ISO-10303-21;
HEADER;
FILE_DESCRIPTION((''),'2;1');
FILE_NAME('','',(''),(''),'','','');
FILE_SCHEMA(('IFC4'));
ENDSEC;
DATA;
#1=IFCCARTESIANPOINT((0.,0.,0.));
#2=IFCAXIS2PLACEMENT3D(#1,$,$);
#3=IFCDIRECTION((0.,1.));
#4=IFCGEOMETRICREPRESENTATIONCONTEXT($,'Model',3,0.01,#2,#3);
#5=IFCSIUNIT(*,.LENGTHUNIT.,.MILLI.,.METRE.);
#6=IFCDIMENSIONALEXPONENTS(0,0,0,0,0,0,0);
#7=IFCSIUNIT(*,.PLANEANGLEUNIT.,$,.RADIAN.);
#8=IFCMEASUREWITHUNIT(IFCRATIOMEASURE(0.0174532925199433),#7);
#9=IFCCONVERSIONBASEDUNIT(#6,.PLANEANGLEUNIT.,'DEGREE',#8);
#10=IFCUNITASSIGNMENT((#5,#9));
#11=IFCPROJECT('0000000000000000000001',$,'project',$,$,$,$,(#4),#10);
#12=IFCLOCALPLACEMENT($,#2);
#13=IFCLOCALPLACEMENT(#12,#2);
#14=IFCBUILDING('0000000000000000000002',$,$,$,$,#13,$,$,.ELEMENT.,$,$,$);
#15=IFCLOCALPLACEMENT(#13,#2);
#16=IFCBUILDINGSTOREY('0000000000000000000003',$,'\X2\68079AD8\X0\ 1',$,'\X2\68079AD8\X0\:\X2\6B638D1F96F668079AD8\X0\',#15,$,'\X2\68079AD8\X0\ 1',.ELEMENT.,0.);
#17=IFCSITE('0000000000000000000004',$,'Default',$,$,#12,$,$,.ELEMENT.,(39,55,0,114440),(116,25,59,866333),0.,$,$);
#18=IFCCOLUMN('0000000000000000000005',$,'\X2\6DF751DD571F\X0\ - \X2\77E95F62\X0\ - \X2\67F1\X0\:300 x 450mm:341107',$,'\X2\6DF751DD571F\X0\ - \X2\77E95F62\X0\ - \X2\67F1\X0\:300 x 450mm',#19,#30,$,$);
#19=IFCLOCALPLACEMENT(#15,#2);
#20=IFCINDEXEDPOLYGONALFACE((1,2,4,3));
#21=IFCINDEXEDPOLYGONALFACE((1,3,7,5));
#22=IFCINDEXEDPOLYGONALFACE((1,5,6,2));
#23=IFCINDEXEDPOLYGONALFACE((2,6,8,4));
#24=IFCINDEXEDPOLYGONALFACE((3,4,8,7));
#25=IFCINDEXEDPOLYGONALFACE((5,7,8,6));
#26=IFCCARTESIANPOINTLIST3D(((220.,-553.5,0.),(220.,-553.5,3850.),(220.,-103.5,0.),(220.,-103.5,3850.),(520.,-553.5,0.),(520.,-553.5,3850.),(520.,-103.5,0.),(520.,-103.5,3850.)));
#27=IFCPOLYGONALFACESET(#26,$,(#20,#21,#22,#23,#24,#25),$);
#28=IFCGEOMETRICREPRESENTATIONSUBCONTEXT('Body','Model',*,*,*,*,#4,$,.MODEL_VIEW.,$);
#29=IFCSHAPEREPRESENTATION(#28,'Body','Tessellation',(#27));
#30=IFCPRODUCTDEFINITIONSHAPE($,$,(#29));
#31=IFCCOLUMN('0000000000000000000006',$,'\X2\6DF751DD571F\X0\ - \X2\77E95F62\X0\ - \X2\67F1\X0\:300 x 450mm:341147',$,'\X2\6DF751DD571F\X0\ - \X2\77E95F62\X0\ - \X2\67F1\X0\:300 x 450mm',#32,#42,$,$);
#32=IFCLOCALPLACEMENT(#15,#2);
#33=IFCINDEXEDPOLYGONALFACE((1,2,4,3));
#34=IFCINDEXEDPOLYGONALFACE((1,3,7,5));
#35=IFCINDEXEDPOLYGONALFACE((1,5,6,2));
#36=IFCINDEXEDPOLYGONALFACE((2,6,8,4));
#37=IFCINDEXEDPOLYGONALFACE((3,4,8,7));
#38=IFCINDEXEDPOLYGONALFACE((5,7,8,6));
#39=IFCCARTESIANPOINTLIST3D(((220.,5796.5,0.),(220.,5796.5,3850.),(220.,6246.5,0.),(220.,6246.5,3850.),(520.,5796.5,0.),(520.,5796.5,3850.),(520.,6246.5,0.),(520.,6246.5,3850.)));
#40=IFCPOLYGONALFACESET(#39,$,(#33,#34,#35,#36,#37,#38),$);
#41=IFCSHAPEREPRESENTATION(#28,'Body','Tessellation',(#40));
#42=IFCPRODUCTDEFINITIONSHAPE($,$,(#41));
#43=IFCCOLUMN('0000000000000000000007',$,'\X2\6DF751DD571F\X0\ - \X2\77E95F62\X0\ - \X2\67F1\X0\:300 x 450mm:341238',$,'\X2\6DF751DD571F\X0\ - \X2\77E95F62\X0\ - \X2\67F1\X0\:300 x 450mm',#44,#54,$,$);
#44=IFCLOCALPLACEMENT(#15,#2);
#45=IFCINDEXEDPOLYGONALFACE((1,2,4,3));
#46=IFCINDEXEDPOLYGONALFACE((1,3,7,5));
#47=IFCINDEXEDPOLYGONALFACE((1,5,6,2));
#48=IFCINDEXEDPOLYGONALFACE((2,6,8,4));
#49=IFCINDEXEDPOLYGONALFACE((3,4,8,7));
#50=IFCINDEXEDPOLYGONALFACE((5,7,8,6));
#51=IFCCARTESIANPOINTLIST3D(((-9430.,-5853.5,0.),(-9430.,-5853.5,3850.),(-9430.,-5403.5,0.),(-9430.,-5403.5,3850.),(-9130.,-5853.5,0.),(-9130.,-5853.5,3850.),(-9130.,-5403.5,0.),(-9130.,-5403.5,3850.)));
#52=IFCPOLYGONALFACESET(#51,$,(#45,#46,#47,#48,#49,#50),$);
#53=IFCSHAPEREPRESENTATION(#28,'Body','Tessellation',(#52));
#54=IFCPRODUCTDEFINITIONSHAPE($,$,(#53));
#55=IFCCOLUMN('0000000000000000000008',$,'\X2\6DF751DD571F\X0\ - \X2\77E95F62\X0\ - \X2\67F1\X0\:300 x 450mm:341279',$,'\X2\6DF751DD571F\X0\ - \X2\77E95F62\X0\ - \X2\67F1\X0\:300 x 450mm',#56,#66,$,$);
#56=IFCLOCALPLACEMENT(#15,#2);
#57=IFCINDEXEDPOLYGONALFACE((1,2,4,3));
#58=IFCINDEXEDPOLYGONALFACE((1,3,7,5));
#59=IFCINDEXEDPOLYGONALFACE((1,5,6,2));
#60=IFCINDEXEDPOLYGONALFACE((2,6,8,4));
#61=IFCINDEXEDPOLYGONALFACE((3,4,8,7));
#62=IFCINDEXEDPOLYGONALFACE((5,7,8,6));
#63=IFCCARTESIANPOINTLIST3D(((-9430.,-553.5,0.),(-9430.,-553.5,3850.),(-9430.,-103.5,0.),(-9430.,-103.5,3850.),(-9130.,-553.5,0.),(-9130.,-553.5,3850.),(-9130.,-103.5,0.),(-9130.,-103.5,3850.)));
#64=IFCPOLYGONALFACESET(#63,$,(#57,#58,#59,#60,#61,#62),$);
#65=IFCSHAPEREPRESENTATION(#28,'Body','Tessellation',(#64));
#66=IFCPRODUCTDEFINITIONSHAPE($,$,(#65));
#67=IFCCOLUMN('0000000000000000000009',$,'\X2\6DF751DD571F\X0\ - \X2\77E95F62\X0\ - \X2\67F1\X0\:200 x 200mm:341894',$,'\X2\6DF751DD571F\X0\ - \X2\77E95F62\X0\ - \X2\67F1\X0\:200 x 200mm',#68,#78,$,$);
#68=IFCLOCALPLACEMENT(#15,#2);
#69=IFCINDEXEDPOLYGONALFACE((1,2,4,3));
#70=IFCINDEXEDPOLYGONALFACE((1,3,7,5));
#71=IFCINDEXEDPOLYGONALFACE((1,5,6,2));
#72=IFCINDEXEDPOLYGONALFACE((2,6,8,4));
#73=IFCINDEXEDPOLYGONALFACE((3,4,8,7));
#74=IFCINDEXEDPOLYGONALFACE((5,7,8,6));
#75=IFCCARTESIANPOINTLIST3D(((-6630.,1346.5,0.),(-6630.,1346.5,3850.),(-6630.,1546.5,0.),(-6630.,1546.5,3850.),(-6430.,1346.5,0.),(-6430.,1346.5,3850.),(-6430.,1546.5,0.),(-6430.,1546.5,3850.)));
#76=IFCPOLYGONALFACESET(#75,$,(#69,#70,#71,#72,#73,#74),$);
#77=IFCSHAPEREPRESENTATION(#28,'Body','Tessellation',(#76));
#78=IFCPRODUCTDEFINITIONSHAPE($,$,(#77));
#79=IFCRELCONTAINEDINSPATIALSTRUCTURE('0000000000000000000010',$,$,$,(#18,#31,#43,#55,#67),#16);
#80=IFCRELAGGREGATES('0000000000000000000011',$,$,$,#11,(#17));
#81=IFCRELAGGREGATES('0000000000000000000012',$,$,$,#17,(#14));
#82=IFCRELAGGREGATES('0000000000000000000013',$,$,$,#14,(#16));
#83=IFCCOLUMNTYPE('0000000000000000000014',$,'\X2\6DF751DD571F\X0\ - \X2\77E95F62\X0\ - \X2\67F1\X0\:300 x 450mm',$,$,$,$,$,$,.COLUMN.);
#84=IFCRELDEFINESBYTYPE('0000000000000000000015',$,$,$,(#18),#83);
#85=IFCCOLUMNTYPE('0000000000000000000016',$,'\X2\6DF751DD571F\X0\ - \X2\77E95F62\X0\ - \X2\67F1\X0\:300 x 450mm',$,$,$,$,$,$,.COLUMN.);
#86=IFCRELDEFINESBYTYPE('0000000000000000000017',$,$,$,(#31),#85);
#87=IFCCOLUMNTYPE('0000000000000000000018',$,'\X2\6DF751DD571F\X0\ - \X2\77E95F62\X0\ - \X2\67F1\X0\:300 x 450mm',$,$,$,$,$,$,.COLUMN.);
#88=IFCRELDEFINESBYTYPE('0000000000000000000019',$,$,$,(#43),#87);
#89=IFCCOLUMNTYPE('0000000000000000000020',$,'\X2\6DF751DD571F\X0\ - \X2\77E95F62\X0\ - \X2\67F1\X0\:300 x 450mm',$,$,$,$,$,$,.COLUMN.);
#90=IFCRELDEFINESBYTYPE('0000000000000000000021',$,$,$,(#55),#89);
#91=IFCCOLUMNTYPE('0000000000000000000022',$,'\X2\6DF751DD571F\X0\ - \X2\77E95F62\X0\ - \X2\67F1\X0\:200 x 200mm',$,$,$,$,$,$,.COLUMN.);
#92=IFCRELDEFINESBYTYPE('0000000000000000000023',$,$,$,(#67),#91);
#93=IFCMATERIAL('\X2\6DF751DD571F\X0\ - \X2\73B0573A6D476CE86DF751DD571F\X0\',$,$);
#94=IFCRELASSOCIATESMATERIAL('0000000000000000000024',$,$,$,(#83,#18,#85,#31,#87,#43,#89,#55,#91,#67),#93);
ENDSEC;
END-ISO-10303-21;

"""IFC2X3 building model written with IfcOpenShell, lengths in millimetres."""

from ifc_helpers import new_model, entity, si_unit, converted_unit, direction, frame, frame_2d, origin, origin_2d_with_axis, place, context, subcontext, project, spatial, rectangle, extrude, source, transform, mapped, material, type_object, type_shapes, element, save


model = new_model("IFC2X3")

# Units and contexts
model_context = context("Model", 3, precision=0.01, world=origin(), true_north=direction((0.0, 1.0)))
body_context = subcontext(model_context, "Body", "Model", "MODEL_VIEW")
ifc_project = project(units=[si_unit("LENGTHUNIT", "METRE", prefix="MILLI"), converted_unit("PLANEANGLEUNIT", "DEGREE", entity("IfcRatioMeasure", 0.0174532925199433), si_unit("PLANEANGLEUNIT", "RADIAN"), dimensions=[0, 0, 0, 0, 0, 0, 0])], contexts=[model_context])

# Site, building, storey
site_placement = place(None, origin())
site = spatial("IfcSite", under=ifc_project, at=site_placement, Name="Default", CompositionType="ELEMENT", RefLatitude=(39, 55, 0, 114440), RefLongitude=(116, 25, 59, 866333), RefElevation=0.0)
building_placement = place(site_placement, origin())
building = spatial("IfcBuilding", under=site, at=building_placement, CompositionType="ELEMENT")
storey_placement = place(building_placement, origin())
storey = spatial("IfcBuildingStorey", under=building, at=storey_placement, Name="标高 1", ObjectType="标高:正负零标高", LongName="标高 1", CompositionType="ELEMENT", Elevation=0.0)

# Columns
ifc_material_1 = material(Name="混凝土 - 现场浇注混凝土")
column_type_1 = type_object("IfcColumnType", Name="混凝土 - 矩形 - 柱:300 x 450mm", PredefinedType="COLUMN", material=ifc_material_1)
shared_shape_1 = source(origin(), body_context, "Body", "SweptSolid", [
    extrude(rectangle(XDim=450.0, YDim=300.0, at=frame_2d((0.0, 0.0), x_axis=(1.0, 0.0))), frame((370.0, -328.5, 0.0), z_axis=(0.0, 0.0, 1.0), x_axis=(0.0, -1.0, 0.0)), (0.0, 0.0, 1.0), 3850.0),
])
type_shapes(column_type_1, [shared_shape_1])
column_1_placement = place(storey_placement, origin())
element("IfcColumn", 1, at=column_1_placement, inside=storey, type_object=column_type_1, material=ifc_material_1, Name="混凝土 - 矩形 - 柱:300 x 450mm:341107", ObjectType="混凝土 - 矩形 - 柱:300 x 450mm", context=body_context, shape_type="MappedRepresentation", body=[
    mapped(shared_shape_1, transform((0.0, 0.0, 0.0), scale=1.0)),
])
column_type_2 = type_object("IfcColumnType", Name="混凝土 - 矩形 - 柱:300 x 450mm", PredefinedType="COLUMN", material=ifc_material_1)
shared_shape_2 = source(origin(), body_context, "Body", "SweptSolid", [
    extrude(rectangle(XDim=450.0, YDim=300.0, at=origin_2d_with_axis()), frame((370.0, 6021.5, 0.0), z_axis=(0.0, 0.0, 1.0), x_axis=(0.0, -1.0, 0.0)), (0.0, 0.0, 1.0), 3850.0),
])
type_shapes(column_type_2, [shared_shape_2])
column_2_placement = place(storey_placement, origin())
element("IfcColumn", 2, at=column_2_placement, inside=storey, type_object=column_type_2, material=ifc_material_1, Name="混凝土 - 矩形 - 柱:300 x 450mm:341147", ObjectType="混凝土 - 矩形 - 柱:300 x 450mm", context=body_context, shape_type="MappedRepresentation", body=[
    mapped(shared_shape_2, transform((0.0, 0.0, 0.0), scale=1.0)),
])
column_type_3 = type_object("IfcColumnType", Name="混凝土 - 矩形 - 柱:300 x 450mm", PredefinedType="COLUMN", material=ifc_material_1)
shared_shape_3 = source(origin(), body_context, "Body", "SweptSolid", [
    extrude(rectangle(XDim=450.0, YDim=300.0, at=frame_2d((0.0, 0.0), x_axis=(1.0, 0.0))), frame((-9280.0, -5628.5, 0.0), z_axis=(0.0, 0.0, 1.0), x_axis=(0.0, -1.0, 0.0)), (0.0, 0.0, 1.0), 3850.0),
])
type_shapes(column_type_3, [shared_shape_3])
column_3_placement = place(storey_placement, origin())
element("IfcColumn", 3, at=column_3_placement, inside=storey, type_object=column_type_3, material=ifc_material_1, Name="混凝土 - 矩形 - 柱:300 x 450mm:341238", ObjectType="混凝土 - 矩形 - 柱:300 x 450mm", context=body_context, shape_type="MappedRepresentation", body=[
    mapped(shared_shape_3, transform((0.0, 0.0, 0.0), scale=1.0)),
])
column_type_4 = type_object("IfcColumnType", Name="混凝土 - 矩形 - 柱:300 x 450mm", PredefinedType="COLUMN", material=ifc_material_1)
shared_shape_4 = source(origin(), body_context, "Body", "SweptSolid", [
    extrude(rectangle(XDim=450.0, YDim=300.0, at=frame_2d((0.0, 0.0), x_axis=(1.0, 0.0))), frame((-9280.0, -328.5, 0.0), z_axis=(0.0, 0.0, 1.0), x_axis=(0.0, -1.0, 0.0)), (0.0, 0.0, 1.0), 3850.0),
])
type_shapes(column_type_4, [shared_shape_4])
column_4_placement = place(storey_placement, origin())
element("IfcColumn", 4, at=column_4_placement, inside=storey, type_object=column_type_4, material=ifc_material_1, Name="混凝土 - 矩形 - 柱:300 x 450mm:341279", ObjectType="混凝土 - 矩形 - 柱:300 x 450mm", context=body_context, shape_type="MappedRepresentation", body=[
    mapped(shared_shape_4, transform((0.0, 0.0, 0.0), scale=1.0)),
])
column_type_5 = type_object("IfcColumnType", Name="混凝土 - 矩形 - 柱:200 x 200mm", PredefinedType="COLUMN", material=ifc_material_1)
shared_shape_5 = source(origin(), body_context, "Body", "SweptSolid", [
    extrude(rectangle(XDim=200.0, YDim=200.0, at=frame_2d((0.0, 0.0), x_axis=(1.0, 0.0))), frame((-6530.0, 1446.5, 0.0), z_axis=(0.0, 0.0, 1.0), x_axis=(0.0, -1.0, 0.0)), (0.0, 0.0, 1.0), 3850.0),
])
type_shapes(column_type_5, [shared_shape_5])
column_5_placement = place(storey_placement, origin())
element("IfcColumn", 5, at=column_5_placement, inside=storey, type_object=column_type_5, material=ifc_material_1, Name="混凝土 - 矩形 - 柱:200 x 200mm:341894", ObjectType="混凝土 - 矩形 - 柱:200 x 200mm", context=body_context, shape_type="MappedRepresentation", body=[
    mapped(shared_shape_5, transform((0.0, 0.0, 0.0), scale=1.0)),
])

save(model, "model.ifc")
